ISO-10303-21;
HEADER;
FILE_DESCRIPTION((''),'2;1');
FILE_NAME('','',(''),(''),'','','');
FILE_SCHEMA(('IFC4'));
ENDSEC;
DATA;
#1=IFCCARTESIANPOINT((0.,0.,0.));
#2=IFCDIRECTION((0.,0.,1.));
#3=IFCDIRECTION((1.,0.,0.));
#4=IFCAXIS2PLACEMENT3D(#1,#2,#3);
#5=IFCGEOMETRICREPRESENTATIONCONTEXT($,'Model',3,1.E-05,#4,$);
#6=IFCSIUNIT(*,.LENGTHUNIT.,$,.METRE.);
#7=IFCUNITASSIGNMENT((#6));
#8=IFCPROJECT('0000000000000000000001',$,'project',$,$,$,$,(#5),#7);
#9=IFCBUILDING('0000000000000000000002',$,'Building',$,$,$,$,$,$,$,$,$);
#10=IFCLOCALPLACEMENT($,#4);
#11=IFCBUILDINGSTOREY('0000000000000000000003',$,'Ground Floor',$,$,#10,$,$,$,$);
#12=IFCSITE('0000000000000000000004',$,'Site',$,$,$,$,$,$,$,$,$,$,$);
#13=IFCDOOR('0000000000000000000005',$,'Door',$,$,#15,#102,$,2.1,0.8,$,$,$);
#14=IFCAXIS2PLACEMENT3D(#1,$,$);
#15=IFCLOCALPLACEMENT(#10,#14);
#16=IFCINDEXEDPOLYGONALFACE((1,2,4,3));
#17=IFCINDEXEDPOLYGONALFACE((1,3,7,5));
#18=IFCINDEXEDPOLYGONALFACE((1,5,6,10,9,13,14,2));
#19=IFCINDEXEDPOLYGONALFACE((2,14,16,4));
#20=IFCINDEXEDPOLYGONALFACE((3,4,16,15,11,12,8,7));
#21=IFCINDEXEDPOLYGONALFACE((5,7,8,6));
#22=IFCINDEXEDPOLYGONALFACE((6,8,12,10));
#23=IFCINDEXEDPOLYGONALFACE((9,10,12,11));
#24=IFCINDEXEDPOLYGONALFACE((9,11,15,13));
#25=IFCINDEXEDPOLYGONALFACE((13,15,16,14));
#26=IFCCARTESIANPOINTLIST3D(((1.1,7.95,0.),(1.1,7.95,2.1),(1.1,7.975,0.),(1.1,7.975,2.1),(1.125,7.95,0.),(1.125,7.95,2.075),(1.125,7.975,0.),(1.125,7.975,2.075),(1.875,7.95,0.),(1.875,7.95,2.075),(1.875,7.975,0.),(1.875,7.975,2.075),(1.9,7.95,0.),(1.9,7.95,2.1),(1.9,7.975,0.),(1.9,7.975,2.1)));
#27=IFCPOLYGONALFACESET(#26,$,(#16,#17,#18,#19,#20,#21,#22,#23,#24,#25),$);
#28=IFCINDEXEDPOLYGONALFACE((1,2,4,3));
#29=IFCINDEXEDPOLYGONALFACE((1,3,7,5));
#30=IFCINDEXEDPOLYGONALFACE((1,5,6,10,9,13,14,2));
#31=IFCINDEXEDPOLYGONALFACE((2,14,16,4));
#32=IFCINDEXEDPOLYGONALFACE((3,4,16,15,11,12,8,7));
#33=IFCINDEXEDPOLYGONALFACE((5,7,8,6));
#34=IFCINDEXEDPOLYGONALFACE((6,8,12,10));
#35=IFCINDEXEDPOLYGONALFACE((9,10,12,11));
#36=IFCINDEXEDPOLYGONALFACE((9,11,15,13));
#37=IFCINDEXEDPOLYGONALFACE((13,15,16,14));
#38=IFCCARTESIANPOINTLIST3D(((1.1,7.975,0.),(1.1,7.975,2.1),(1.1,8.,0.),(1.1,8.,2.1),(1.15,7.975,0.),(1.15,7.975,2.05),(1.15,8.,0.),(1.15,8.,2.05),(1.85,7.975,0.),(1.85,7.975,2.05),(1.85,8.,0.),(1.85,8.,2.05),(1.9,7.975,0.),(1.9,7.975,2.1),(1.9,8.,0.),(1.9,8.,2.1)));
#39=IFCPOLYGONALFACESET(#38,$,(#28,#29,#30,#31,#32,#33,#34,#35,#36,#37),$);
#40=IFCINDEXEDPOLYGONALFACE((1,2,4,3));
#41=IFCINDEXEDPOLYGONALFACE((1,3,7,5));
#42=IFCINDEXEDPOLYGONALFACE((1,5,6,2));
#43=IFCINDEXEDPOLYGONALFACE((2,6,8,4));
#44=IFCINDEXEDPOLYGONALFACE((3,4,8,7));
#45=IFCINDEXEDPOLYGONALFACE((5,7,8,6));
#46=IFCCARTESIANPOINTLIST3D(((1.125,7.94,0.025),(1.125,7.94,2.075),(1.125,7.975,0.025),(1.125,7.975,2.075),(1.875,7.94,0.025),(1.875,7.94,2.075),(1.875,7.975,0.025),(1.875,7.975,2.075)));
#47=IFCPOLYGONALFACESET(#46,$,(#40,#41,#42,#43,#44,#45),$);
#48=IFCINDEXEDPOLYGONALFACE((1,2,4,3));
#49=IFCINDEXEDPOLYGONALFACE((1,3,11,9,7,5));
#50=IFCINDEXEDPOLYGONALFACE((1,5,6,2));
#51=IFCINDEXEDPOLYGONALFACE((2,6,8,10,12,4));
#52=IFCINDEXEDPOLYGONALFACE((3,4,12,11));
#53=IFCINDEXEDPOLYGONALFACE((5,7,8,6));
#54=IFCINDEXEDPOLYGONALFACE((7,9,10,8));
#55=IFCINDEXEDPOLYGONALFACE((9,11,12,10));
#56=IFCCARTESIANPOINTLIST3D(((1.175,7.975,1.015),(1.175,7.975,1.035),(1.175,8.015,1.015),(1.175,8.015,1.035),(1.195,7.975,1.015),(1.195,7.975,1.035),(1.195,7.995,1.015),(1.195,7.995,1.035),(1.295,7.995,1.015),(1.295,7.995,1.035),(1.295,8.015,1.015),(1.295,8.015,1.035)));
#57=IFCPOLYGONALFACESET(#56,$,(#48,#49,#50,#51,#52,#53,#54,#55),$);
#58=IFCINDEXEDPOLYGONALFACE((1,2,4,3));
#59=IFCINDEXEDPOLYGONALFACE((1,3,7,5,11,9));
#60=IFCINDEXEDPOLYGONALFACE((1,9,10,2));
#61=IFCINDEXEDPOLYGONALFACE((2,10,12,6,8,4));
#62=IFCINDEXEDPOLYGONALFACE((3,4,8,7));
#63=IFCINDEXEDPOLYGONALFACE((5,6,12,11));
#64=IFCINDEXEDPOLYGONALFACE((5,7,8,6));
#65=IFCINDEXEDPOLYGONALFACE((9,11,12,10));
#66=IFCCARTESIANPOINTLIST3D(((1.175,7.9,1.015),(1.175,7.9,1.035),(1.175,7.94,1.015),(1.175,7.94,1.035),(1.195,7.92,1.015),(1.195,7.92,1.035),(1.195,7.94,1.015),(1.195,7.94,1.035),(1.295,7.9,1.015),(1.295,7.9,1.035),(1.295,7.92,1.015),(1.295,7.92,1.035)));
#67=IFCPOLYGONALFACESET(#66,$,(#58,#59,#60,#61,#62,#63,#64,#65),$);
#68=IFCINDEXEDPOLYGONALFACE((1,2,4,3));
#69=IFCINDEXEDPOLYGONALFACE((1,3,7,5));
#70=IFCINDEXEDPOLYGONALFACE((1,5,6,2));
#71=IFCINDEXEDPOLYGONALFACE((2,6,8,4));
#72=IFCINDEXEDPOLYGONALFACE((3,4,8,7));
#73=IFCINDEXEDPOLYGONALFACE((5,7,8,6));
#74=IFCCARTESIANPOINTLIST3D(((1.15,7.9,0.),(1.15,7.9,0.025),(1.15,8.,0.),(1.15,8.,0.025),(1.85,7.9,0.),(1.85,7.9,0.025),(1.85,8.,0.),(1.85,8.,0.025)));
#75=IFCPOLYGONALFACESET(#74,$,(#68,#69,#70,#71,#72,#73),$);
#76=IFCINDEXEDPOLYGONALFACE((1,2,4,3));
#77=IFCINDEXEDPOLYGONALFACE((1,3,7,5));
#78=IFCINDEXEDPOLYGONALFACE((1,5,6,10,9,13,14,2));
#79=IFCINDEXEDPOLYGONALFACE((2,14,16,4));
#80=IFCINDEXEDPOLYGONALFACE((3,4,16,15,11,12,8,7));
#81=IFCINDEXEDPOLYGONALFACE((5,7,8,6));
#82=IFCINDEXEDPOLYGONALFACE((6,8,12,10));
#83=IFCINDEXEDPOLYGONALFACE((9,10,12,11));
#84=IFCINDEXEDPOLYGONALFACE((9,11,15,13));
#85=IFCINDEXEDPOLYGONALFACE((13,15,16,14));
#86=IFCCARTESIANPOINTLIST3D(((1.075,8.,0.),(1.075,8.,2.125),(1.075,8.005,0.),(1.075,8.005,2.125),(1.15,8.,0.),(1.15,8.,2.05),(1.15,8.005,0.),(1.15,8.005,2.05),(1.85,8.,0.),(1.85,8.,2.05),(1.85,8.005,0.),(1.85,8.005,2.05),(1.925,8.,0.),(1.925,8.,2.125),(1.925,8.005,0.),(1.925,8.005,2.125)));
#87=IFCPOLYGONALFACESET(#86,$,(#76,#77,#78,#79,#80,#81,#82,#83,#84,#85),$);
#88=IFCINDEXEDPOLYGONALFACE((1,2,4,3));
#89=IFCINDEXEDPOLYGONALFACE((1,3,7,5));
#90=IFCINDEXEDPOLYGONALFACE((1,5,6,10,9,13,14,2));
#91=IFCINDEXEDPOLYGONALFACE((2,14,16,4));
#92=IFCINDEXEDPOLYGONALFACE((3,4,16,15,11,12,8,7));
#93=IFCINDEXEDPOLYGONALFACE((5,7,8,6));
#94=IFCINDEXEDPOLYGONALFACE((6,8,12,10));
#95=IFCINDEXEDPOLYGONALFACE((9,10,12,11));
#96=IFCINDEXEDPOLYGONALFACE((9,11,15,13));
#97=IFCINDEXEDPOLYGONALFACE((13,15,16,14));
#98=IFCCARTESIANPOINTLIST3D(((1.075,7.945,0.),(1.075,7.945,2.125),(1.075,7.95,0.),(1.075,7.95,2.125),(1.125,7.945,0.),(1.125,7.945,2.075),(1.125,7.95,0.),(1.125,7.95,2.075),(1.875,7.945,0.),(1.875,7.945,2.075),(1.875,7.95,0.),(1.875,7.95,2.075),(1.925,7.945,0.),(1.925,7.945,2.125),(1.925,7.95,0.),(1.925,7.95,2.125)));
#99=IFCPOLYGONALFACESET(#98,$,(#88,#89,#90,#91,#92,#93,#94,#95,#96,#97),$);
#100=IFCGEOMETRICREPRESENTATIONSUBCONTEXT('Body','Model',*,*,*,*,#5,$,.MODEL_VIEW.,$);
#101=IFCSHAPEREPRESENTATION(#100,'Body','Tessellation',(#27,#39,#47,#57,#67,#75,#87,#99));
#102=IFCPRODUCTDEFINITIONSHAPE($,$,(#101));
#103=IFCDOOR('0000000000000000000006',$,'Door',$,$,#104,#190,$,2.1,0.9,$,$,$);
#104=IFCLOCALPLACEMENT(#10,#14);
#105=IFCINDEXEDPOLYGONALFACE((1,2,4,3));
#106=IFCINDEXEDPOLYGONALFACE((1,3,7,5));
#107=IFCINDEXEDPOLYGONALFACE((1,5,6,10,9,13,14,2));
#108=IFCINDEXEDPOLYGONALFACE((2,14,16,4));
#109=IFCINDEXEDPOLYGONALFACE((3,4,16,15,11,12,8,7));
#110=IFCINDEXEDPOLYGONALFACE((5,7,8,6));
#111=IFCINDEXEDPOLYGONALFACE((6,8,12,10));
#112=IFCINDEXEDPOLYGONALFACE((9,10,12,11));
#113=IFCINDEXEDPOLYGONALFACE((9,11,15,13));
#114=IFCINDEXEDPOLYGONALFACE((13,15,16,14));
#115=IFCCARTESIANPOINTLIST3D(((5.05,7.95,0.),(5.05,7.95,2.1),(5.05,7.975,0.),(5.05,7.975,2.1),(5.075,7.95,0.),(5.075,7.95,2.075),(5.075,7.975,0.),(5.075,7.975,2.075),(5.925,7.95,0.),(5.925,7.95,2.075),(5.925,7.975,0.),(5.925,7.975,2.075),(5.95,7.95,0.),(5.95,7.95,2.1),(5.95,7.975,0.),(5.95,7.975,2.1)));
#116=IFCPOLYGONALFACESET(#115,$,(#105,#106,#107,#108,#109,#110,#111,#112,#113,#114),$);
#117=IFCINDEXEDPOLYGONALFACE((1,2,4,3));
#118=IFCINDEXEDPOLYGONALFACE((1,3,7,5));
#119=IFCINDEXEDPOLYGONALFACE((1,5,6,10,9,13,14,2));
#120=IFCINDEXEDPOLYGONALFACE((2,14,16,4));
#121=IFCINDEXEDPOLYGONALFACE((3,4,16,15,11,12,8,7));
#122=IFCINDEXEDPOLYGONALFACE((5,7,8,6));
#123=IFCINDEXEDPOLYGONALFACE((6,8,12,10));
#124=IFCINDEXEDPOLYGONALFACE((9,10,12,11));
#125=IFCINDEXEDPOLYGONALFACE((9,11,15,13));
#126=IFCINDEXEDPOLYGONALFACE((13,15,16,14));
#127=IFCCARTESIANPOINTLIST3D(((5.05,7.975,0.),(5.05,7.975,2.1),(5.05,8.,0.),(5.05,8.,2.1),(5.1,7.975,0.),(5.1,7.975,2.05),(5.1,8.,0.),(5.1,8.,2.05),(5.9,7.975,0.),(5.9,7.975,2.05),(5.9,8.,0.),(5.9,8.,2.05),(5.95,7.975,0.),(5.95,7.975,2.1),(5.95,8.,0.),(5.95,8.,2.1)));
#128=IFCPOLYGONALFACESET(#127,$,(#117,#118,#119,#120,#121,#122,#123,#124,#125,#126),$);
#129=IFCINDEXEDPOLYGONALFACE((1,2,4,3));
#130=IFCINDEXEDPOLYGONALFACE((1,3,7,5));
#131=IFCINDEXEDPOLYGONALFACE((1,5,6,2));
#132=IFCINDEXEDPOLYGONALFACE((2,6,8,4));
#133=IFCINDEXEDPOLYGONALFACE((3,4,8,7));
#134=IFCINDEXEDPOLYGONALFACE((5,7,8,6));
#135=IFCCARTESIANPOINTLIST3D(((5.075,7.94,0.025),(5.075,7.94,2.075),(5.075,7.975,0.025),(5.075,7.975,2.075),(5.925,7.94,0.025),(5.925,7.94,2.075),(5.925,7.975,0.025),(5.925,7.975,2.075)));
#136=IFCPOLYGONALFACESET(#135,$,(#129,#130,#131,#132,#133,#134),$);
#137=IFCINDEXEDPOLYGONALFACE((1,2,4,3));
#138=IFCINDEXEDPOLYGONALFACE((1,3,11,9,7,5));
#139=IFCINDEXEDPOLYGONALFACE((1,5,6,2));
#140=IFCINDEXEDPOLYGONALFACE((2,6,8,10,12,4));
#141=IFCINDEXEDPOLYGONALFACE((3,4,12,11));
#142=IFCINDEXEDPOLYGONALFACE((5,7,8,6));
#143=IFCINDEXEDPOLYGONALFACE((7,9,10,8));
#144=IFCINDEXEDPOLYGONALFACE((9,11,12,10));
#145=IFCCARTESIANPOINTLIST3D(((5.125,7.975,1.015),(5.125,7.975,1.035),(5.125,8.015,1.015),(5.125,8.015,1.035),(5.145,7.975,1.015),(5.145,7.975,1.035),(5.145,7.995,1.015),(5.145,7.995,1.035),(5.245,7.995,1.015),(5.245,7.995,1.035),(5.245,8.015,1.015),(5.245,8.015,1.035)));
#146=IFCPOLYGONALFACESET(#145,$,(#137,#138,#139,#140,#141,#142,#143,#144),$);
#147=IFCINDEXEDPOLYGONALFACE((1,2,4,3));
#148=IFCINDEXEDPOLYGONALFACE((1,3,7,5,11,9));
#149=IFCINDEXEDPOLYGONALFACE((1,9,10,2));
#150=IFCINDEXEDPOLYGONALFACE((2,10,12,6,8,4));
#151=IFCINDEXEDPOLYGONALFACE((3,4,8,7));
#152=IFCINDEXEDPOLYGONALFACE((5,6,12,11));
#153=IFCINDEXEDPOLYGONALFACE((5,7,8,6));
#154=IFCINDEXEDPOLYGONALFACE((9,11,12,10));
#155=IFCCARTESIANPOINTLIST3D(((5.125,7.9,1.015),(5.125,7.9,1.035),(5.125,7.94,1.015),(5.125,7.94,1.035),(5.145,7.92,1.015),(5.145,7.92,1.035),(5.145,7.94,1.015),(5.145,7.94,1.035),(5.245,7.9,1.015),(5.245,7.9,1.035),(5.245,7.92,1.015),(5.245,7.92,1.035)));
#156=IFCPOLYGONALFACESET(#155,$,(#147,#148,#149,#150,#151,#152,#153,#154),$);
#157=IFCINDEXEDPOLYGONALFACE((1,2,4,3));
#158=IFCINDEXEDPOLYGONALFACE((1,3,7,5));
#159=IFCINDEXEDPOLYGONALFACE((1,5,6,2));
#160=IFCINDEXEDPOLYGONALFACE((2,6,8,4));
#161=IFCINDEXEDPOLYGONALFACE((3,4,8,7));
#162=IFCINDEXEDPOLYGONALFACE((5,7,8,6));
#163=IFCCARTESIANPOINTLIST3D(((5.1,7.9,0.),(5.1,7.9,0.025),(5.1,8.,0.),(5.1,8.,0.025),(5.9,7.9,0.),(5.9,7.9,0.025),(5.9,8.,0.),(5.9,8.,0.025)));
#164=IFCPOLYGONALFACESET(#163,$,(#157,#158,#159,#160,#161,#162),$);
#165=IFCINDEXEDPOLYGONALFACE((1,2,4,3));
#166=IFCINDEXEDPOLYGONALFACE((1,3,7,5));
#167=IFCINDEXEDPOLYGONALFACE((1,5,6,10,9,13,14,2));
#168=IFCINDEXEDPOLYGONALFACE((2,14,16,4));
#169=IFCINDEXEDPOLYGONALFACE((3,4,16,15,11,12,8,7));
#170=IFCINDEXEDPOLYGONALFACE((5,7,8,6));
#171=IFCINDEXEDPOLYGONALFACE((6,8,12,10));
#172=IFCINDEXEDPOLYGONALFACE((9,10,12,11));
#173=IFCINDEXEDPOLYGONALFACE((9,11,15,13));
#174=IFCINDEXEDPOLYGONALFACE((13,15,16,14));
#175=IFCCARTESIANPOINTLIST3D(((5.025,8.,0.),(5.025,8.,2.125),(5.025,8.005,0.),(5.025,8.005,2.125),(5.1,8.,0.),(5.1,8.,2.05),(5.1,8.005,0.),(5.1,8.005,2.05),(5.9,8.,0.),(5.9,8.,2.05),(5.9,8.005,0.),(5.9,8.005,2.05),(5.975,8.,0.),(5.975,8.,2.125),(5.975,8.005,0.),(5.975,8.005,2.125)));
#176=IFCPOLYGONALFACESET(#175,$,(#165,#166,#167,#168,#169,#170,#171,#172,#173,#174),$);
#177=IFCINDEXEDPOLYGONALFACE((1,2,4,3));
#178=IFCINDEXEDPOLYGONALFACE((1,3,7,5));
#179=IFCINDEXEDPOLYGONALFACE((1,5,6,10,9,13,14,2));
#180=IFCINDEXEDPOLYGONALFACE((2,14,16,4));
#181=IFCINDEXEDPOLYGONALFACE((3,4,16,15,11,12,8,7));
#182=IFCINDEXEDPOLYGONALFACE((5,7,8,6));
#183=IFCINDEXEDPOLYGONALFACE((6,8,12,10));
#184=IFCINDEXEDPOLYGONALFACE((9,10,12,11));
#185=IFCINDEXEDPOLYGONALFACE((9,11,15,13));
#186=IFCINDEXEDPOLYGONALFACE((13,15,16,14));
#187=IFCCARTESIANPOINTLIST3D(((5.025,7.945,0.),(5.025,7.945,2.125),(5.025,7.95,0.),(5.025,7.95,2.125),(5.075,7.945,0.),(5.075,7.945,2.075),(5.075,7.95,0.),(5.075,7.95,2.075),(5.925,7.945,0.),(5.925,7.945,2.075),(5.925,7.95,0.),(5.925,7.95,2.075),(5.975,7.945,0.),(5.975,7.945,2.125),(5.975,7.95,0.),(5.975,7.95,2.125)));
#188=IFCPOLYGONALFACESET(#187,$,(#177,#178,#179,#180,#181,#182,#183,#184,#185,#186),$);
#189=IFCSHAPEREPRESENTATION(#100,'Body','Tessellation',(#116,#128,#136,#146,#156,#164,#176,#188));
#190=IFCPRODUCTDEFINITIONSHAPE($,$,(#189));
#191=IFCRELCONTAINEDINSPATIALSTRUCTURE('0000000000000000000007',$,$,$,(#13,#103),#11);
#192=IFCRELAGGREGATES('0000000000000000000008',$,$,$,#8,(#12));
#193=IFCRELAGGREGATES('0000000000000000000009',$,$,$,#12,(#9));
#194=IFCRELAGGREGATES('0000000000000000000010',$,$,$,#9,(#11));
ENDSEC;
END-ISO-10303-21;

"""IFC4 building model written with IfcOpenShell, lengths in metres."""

from ifc_helpers import new_model, si_unit, frame, origin_with_axes, place, context, subcontext, project, spatial, line, indexed_curve, outline, extrude, element, save


model = new_model("IFC4")

# Units and contexts
model_context = context("Model", 3, precision=1e-05, world=origin_with_axes())
body_context = subcontext(model_context, "Body", "Model", "MODEL_VIEW")
ifc_project = project(units=[si_unit("LENGTHUNIT", "METRE")], contexts=[model_context])

# Site, building, storey
site = spatial("IfcSite", under=ifc_project, Name="Site")
building = spatial("IfcBuilding", under=site, Name="Building")
storey_placement = place(None, origin_with_axes())
storey = spatial("IfcBuildingStorey", under=building, at=storey_placement, Name="Ground Floor")

# Doors
door_1_placement = place(storey_placement, frame((1.9, 8.0, 0.0), z_axis=(0.0, 0.0, 1.0), x_axis=(-1.0, 0.0, 0.0)))
element("IfcDoor", 1, at=door_1_placement, inside=storey, Name="Door", OverallHeight=2.1, OverallWidth=0.8, context=body_context, shape_type="SweptSolid", body=[
    extrude(outline(indexed_curve([(0.0, 0.0), (0.0, 2.1), (0.8, 2.1), (0.8, 0.0), (0.775, 0.0), (0.775, 2.075), (0.025, 2.075), (0.025, 0.0)], segments=[line(1, 2, 3, 4, 5, 6, 7, 8, 1)])), frame((0.0, 0.025, 0.0), z_axis=(0.0, -1.0, 0.0), x_axis=(1.0, 0.0, 0.0)), (0.0, 0.0, -1.0), 0.025),
    extrude(outline(indexed_curve([(0.0, 0.0), (0.0, 2.1), (0.8, 2.1), (0.8, 0.0), (0.75, 0.0), (0.75, 2.05), (0.05, 2.05), (0.05, 0.0)], segments=[line(1, 2, 3, 4, 5, 6, 7, 8, 1)])), frame((0.0, 0.0, 0.0), z_axis=(0.0, -1.0, 0.0), x_axis=(1.0, 0.0, 0.0)), (0.0, 0.0, -1.0), 0.025),
    extrude(outline(indexed_curve([(0.0, 0.0), (0.75, 0.0), (0.75, 0.035), (0.0, 0.035)], segments=[line(1, 2, 3, 4, 1)])), frame((0.025, 0.025, 0.025), z_axis=(0.0, 0.0, 1.0), x_axis=(1.0, 0.0, 0.0)), (0.0, 0.0, 1.0), 2.05),
    extrude(outline(indexed_curve([(0.0, 0.0), (0.0, -0.04), (-0.12, -0.04), (-0.12, -0.02), (-0.02, -0.02), (-0.02, 0.0)], segments=[line(1, 2, 3, 4, 5, 6, 1)])), frame((0.725, 0.025, 1.015), z_axis=(0.0, 0.0, 1.0), x_axis=(1.0, 0.0, 0.0)), (0.0, 0.0, 1.0), 0.02),
    extrude(outline(indexed_curve([(0.0, 0.0), (0.0, 0.04), (-0.12, 0.04), (-0.12, 0.02), (-0.02, 0.02), (-0.02, 0.0)], segments=[line(1, 2, 3, 4, 5, 6, 1)])), frame((0.725, 0.06, 1.015), z_axis=(0.0, 0.0, 1.0), x_axis=(1.0, 0.0, 0.0)), (0.0, 0.0, 1.0), 0.02),
    extrude(outline(indexed_curve([(0.0, 0.0), (0.7, 0.0), (0.7, 0.1), (0.0, 0.1)], segments=[line(1, 2, 3, 4, 1)])), frame((0.05, 0.0, 0.0), z_axis=(0.0, 0.0, 1.0), x_axis=(1.0, 0.0, 0.0)), (0.0, 0.0, 1.0), 0.025),
    extrude(outline(indexed_curve([(0.0, 0.0), (0.0, 2.125), (0.85, 2.125), (0.85, 0.0), (0.775, 0.0), (0.775, 2.05), (0.075, 2.05), (0.075, 0.0)], segments=[line(1, 2, 3, 4, 5, 6, 7, 8, 1)])), frame((-0.025, -0.005, 0.0), z_axis=(0.0, -1.0, 0.0), x_axis=(1.0, 0.0, 0.0)), (0.0, 0.0, -1.0), 0.005),
    extrude(outline(indexed_curve([(0.0, 0.0), (0.0, 2.125), (0.85, 2.125), (0.85, 0.0), (0.8, 0.0), (0.8, 2.075), (0.05, 2.075), (0.05, 0.0)], segments=[line(1, 2, 3, 4, 5, 6, 7, 8, 1)])), frame((-0.025, 0.05, 0.0), z_axis=(0.0, -1.0, 0.0), x_axis=(1.0, 0.0, 0.0)), (0.0, 0.0, -1.0), 0.005),
])
door_2_placement = place(storey_placement, frame((5.95, 8.0, 0.0), z_axis=(0.0, 0.0, 1.0), x_axis=(-1.0, 0.0, 0.0)))
element("IfcDoor", 2, at=door_2_placement, inside=storey, Name="Door", OverallHeight=2.1, OverallWidth=0.9, context=body_context, shape_type="SweptSolid", body=[
    extrude(outline(indexed_curve([(0.0, 0.0), (0.0, 2.1), (0.9, 2.1), (0.9, 0.0), (0.875, 0.0), (0.875, 2.075), (0.025, 2.075), (0.025, 0.0)], segments=[line(1, 2, 3, 4, 5, 6, 7, 8, 1)])), frame((0.0, 0.025, 0.0), z_axis=(0.0, -1.0, 0.0), x_axis=(1.0, 0.0, 0.0)), (0.0, 0.0, -1.0), 0.025),
    extrude(outline(indexed_curve([(0.0, 0.0), (0.0, 2.1), (0.9, 2.1), (0.9, 0.0), (0.85, 0.0), (0.85, 2.05), (0.05, 2.05), (0.05, 0.0)], segments=[line(1, 2, 3, 4, 5, 6, 7, 8, 1)])), frame((0.0, 0.0, 0.0), z_axis=(0.0, -1.0, 0.0), x_axis=(1.0, 0.0, 0.0)), (0.0, 0.0, -1.0), 0.025),
    extrude(outline(indexed_curve([(0.0, 0.0), (0.85, 0.0), (0.85, 0.035), (0.0, 0.035)], segments=[line(1, 2, 3, 4, 1)])), frame((0.025, 0.025, 0.025), z_axis=(0.0, 0.0, 1.0), x_axis=(1.0, 0.0, 0.0)), (0.0, 0.0, 1.0), 2.05),
    extrude(outline(indexed_curve([(0.0, 0.0), (0.0, -0.04), (-0.12, -0.04), (-0.12, -0.02), (-0.02, -0.02), (-0.02, 0.0)], segments=[line(1, 2, 3, 4, 5, 6, 1)])), frame((0.825, 0.025, 1.015), z_axis=(0.0, 0.0, 1.0), x_axis=(1.0, 0.0, 0.0)), (0.0, 0.0, 1.0), 0.02),
    extrude(outline(indexed_curve([(0.0, 0.0), (0.0, 0.04), (-0.12, 0.04), (-0.12, 0.02), (-0.02, 0.02), (-0.02, 0.0)], segments=[line(1, 2, 3, 4, 5, 6, 1)])), frame((0.825, 0.06, 1.015), z_axis=(0.0, 0.0, 1.0), x_axis=(1.0, 0.0, 0.0)), (0.0, 0.0, 1.0), 0.02),
    extrude(outline(indexed_curve([(0.0, 0.0), (0.8, 0.0), (0.8, 0.1), (0.0, 0.1)], segments=[line(1, 2, 3, 4, 1)])), frame((0.05, 0.0, 0.0), z_axis=(0.0, 0.0, 1.0), x_axis=(1.0, 0.0, 0.0)), (0.0, 0.0, 1.0), 0.025),
    extrude(outline(indexed_curve([(0.0, 0.0), (0.0, 2.125), (0.95, 2.125), (0.95, 0.0), (0.875, 0.0), (0.875, 2.05), (0.075, 2.05), (0.075, 0.0)], segments=[line(1, 2, 3, 4, 5, 6, 7, 8, 1)])), frame((-0.025, -0.005, 0.0), z_axis=(0.0, -1.0, 0.0), x_axis=(1.0, 0.0, 0.0)), (0.0, 0.0, -1.0), 0.005),
    extrude(outline(indexed_curve([(0.0, 0.0), (0.0, 2.125), (0.95, 2.125), (0.95, 0.0), (0.9, 0.0), (0.9, 2.075), (0.05, 2.075), (0.05, 0.0)], segments=[line(1, 2, 3, 4, 5, 6, 7, 8, 1)])), frame((-0.025, 0.05, 0.0), z_axis=(0.0, -1.0, 0.0), x_axis=(1.0, 0.0, 0.0)), (0.0, 0.0, -1.0), 0.005),
])

save(model, "model.ifc")
